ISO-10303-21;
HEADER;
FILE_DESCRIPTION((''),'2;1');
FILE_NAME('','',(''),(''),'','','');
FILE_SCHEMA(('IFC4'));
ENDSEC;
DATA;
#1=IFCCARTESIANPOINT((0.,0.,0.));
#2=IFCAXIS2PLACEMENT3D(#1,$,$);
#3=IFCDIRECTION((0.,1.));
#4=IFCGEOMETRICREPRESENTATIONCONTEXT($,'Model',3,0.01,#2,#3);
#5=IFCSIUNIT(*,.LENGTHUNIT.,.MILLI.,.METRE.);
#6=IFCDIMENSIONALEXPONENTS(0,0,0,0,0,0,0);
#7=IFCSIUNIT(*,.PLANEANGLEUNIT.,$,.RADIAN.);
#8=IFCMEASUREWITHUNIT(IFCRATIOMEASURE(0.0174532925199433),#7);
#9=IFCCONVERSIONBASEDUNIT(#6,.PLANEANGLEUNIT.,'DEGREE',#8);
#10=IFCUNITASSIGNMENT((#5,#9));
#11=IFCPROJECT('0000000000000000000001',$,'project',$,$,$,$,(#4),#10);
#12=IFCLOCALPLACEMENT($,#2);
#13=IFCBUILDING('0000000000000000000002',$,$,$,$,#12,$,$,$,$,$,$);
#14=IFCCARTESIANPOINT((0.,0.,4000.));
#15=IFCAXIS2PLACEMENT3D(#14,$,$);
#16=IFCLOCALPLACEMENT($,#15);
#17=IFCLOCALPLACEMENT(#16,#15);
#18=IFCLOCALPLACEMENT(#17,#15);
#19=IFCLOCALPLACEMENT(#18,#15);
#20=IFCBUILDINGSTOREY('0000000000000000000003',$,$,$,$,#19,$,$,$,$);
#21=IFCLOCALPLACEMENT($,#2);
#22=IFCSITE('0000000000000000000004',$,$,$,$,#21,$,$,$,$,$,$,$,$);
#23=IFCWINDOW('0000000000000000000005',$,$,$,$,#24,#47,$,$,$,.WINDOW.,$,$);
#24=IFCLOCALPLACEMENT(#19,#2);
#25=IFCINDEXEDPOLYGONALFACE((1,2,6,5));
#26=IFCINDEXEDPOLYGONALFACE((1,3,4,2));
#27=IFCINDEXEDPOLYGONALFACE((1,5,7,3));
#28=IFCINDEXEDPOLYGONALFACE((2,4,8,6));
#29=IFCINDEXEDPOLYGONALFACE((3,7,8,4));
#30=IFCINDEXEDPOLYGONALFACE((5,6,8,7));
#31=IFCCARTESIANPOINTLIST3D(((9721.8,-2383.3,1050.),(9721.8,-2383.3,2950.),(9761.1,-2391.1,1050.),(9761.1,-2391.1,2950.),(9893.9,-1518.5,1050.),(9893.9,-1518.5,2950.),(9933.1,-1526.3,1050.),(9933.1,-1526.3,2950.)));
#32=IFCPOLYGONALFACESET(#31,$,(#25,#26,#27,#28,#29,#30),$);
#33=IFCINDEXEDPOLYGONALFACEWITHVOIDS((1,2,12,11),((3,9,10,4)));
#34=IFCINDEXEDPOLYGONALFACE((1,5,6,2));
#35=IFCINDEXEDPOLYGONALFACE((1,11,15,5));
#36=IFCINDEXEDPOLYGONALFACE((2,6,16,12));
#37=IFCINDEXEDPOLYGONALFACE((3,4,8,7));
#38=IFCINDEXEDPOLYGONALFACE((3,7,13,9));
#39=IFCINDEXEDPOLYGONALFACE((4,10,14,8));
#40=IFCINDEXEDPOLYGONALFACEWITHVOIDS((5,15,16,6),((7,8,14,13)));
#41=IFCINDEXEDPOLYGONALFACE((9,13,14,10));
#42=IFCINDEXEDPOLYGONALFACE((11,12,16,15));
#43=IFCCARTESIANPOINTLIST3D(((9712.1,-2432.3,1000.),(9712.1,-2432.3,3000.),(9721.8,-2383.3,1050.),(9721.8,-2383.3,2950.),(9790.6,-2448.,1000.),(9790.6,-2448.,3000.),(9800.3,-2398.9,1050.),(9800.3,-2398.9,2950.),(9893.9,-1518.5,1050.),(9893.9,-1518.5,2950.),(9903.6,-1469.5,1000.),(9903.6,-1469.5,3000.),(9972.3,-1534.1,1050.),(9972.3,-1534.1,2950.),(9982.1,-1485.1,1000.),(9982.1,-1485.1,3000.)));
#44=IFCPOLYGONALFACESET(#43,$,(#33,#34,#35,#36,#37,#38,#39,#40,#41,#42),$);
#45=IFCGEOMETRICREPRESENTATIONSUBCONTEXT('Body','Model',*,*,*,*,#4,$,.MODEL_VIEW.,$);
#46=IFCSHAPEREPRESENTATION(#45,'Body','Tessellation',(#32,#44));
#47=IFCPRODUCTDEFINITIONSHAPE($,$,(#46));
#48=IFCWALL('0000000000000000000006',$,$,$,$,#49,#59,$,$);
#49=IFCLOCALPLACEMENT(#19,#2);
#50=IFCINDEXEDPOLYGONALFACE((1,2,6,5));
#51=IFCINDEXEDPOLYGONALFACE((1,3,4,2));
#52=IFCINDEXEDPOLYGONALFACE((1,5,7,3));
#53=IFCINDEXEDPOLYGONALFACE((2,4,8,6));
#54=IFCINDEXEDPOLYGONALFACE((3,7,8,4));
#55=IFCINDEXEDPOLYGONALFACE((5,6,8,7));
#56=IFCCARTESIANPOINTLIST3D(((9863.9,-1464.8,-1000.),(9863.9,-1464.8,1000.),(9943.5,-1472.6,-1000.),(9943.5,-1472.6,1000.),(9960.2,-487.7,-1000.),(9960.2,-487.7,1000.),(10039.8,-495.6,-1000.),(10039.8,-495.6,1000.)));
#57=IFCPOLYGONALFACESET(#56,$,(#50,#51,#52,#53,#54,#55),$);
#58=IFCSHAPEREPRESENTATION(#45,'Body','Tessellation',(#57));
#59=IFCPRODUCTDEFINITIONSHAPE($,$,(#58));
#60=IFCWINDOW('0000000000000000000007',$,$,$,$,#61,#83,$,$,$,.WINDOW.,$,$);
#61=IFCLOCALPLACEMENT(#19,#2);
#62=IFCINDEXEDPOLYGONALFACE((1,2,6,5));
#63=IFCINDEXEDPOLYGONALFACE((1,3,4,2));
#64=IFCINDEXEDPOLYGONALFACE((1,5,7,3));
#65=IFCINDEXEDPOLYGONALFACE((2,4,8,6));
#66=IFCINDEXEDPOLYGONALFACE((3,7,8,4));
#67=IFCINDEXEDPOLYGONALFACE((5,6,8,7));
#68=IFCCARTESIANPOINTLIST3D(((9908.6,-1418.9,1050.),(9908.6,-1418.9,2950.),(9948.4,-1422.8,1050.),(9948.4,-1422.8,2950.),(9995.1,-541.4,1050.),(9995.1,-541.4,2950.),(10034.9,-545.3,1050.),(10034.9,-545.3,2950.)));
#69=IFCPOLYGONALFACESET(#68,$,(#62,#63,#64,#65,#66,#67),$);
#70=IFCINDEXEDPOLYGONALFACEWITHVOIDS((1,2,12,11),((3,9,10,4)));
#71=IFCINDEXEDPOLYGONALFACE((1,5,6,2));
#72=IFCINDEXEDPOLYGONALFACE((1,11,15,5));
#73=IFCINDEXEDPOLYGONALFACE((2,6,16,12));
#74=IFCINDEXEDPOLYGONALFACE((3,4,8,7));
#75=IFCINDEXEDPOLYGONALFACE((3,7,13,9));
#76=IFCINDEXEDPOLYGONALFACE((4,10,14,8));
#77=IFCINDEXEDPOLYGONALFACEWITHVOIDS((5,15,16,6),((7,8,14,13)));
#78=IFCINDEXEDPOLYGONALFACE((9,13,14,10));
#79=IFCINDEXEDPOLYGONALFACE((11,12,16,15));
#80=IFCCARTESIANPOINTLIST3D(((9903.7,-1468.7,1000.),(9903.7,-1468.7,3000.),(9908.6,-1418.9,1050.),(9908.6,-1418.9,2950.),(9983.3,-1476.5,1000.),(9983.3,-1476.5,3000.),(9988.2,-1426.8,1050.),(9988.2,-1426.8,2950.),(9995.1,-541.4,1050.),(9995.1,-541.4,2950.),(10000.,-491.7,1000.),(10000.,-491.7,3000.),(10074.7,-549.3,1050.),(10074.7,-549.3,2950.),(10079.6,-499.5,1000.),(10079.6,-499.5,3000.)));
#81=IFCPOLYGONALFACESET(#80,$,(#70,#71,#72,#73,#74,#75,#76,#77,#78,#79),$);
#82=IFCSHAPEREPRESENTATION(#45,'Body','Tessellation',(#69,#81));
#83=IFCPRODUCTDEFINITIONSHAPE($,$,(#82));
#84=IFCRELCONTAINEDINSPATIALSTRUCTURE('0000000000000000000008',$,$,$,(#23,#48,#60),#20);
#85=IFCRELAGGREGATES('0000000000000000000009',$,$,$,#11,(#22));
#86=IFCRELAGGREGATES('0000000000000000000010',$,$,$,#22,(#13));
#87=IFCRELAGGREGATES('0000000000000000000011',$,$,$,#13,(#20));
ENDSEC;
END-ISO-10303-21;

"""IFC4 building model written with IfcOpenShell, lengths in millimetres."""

from ifc_helpers import new_model, entity, si_unit, converted_unit, direction, frame, origin, origin_2d, place, context, subcontext, project, spatial, rectangle, extrude, element, save


model = new_model("IFC4")

# Units and contexts
model_context = context("Model", 3, precision=0.01, world=origin(), true_north=direction((0.0, 1.0)))
body_context = subcontext(model_context, "Body", "Model", "MODEL_VIEW")
ifc_project = project(units=[si_unit("LENGTHUNIT", "METRE", prefix="MILLI"), converted_unit("PLANEANGLEUNIT", "DEGREE", entity("IfcRatioMeasure", 0.0174532925199433), si_unit("PLANEANGLEUNIT", "RADIAN"), dimensions=[0, 0, 0, 0, 0, 0, 0])], contexts=[model_context])

# Site, building, storey
site_placement = place(None, origin())
site = spatial("IfcSite", under=ifc_project, at=site_placement)
building_placement = place(None, origin())
building = spatial("IfcBuilding", under=site, at=building_placement)
placement_1 = place(None, frame((0.0, 0.0, 4000.0)))
placement_2 = place(placement_1, frame((0.0, 0.0, 4000.0)))
placement_3 = place(placement_2, frame((0.0, 0.0, 4000.0)))
storey_placement = place(placement_3, frame((0.0, 0.0, 4000.0)))
storey = spatial("IfcBuildingStorey", under=building, at=storey_placement)

# Shared definitions
cartesian_point_1 = entity("IfcCartesianPoint", [-440.9, -950.0])
shared_polyline = entity("IfcPolyline", [cartesian_point_1, entity("IfcCartesianPoint", [-440.9, 950.0]), entity("IfcCartesianPoint", [-440.9, 950.0]), entity("IfcCartesianPoint", [440.9, 950.0]), entity("IfcCartesianPoint", [440.9, 950.0]), entity("IfcCartesianPoint", [440.9, -950.0]), entity("IfcCartesianPoint", [440.9, -950.0]), entity("IfcCartesianPoint", [-440.9, -950.0]), cartesian_point_1])

# Window
window_1_placement = place(storey_placement, frame((9807.9, -1950.9, 2000.0), z_axis=(0.0, 0.0, 1.0), x_axis=(1950.90229, 9807.852989, 0.0)))
cartesian_point_2 = entity("IfcCartesianPoint", [-490.9, -1000.0])
element("IfcWindow", 1, at=window_1_placement, inside=storey, PredefinedType="WINDOW", context=body_context, shape_type="SweptSolid", body=[
    entity("IfcExtrudedAreaSolid", entity("IfcArbitraryClosedProfileDef", "AREA", None, shared_polyline), entity("IfcAxis2Placement3D", entity("IfcCartesianPoint", [0.0, 0.0, 0.0]), entity("IfcDirection", [0.0, -1.0, 0.0]), entity("IfcDirection", [1.0, 0.0, 0.0])), entity("IfcDirection", [0.0, 0.0, 1.0]), 40.0),
    entity("IfcExtrudedAreaSolid", entity("IfcArbitraryProfileDefWithVoids", "AREA", None, entity("IfcPolyline", [cartesian_point_2, entity("IfcCartesianPoint", [-490.9, 1000.0]), entity("IfcCartesianPoint", [-490.9, 1000.0]), entity("IfcCartesianPoint", [490.9, 1000.0]), entity("IfcCartesianPoint", [490.9, 1000.0]), entity("IfcCartesianPoint", [490.9, -1000.0]), entity("IfcCartesianPoint", [490.9, -1000.0]), entity("IfcCartesianPoint", [-490.9, -1000.0]), cartesian_point_2]), [shared_polyline]), entity("IfcAxis2Placement3D", entity("IfcCartesianPoint", [0.0, 0.0, 0.0]), entity("IfcDirection", [0.0, -1.0, 0.0]), entity("IfcDirection", [1.0, 0.0, 0.0])), entity("IfcDirection", [0.0, 0.0, 1.0]), 80.0),
])

# Wall
wall_1_placement = place(storey_placement, frame((9951.8, -980.2, -1000.0), z_axis=(0.0, 0.0, 1.0), x_axis=(980.172434, 9951.847165, 0.0)))
element("IfcWall", 2, at=wall_1_placement, inside=storey, context=body_context, shape_type="SweptSolid", body=[
    extrude(rectangle(XDim=981.7, YDim=80.0, at=origin_2d()), origin(), (0.0, 0.0, 1.0), 2000.0),
])

# Window
window_2_placement = place(storey_placement, frame((9951.8, -980.2, 2000.0), z_axis=(0.0, 0.0, 1.0), x_axis=(980.172434, 9951.847165, 0.0)))
cartesian_point_3 = entity("IfcCartesianPoint", [-490.9, -1000.0])
element("IfcWindow", 3, at=window_2_placement, inside=storey, PredefinedType="WINDOW", context=body_context, shape_type="SweptSolid", body=[
    entity("IfcExtrudedAreaSolid", entity("IfcArbitraryClosedProfileDef", "AREA", None, shared_polyline), entity("IfcAxis2Placement3D", entity("IfcCartesianPoint", [0.0, 0.0, 0.0]), entity("IfcDirection", [0.0, -1.0, 0.0]), entity("IfcDirection", [1.0, 0.0, 0.0])), entity("IfcDirection", [0.0, 0.0, 1.0]), 40.0),
    entity("IfcExtrudedAreaSolid", entity("IfcArbitraryProfileDefWithVoids", "AREA", None, entity("IfcPolyline", [cartesian_point_3, entity("IfcCartesianPoint", [-490.9, 1000.0]), entity("IfcCartesianPoint", [-490.9, 1000.0]), entity("IfcCartesianPoint", [490.9, 1000.0]), entity("IfcCartesianPoint", [490.9, 1000.0]), entity("IfcCartesianPoint", [490.9, -1000.0]), entity("IfcCartesianPoint", [490.9, -1000.0]), entity("IfcCartesianPoint", [-490.9, -1000.0]), cartesian_point_3]), [shared_polyline]), entity("IfcAxis2Placement3D", entity("IfcCartesianPoint", [0.0, 0.0, 0.0]), entity("IfcDirection", [0.0, -1.0, 0.0]), entity("IfcDirection", [1.0, 0.0, 0.0])), entity("IfcDirection", [0.0, 0.0, 1.0]), 80.0),
])

save(model, "model.ifc")
